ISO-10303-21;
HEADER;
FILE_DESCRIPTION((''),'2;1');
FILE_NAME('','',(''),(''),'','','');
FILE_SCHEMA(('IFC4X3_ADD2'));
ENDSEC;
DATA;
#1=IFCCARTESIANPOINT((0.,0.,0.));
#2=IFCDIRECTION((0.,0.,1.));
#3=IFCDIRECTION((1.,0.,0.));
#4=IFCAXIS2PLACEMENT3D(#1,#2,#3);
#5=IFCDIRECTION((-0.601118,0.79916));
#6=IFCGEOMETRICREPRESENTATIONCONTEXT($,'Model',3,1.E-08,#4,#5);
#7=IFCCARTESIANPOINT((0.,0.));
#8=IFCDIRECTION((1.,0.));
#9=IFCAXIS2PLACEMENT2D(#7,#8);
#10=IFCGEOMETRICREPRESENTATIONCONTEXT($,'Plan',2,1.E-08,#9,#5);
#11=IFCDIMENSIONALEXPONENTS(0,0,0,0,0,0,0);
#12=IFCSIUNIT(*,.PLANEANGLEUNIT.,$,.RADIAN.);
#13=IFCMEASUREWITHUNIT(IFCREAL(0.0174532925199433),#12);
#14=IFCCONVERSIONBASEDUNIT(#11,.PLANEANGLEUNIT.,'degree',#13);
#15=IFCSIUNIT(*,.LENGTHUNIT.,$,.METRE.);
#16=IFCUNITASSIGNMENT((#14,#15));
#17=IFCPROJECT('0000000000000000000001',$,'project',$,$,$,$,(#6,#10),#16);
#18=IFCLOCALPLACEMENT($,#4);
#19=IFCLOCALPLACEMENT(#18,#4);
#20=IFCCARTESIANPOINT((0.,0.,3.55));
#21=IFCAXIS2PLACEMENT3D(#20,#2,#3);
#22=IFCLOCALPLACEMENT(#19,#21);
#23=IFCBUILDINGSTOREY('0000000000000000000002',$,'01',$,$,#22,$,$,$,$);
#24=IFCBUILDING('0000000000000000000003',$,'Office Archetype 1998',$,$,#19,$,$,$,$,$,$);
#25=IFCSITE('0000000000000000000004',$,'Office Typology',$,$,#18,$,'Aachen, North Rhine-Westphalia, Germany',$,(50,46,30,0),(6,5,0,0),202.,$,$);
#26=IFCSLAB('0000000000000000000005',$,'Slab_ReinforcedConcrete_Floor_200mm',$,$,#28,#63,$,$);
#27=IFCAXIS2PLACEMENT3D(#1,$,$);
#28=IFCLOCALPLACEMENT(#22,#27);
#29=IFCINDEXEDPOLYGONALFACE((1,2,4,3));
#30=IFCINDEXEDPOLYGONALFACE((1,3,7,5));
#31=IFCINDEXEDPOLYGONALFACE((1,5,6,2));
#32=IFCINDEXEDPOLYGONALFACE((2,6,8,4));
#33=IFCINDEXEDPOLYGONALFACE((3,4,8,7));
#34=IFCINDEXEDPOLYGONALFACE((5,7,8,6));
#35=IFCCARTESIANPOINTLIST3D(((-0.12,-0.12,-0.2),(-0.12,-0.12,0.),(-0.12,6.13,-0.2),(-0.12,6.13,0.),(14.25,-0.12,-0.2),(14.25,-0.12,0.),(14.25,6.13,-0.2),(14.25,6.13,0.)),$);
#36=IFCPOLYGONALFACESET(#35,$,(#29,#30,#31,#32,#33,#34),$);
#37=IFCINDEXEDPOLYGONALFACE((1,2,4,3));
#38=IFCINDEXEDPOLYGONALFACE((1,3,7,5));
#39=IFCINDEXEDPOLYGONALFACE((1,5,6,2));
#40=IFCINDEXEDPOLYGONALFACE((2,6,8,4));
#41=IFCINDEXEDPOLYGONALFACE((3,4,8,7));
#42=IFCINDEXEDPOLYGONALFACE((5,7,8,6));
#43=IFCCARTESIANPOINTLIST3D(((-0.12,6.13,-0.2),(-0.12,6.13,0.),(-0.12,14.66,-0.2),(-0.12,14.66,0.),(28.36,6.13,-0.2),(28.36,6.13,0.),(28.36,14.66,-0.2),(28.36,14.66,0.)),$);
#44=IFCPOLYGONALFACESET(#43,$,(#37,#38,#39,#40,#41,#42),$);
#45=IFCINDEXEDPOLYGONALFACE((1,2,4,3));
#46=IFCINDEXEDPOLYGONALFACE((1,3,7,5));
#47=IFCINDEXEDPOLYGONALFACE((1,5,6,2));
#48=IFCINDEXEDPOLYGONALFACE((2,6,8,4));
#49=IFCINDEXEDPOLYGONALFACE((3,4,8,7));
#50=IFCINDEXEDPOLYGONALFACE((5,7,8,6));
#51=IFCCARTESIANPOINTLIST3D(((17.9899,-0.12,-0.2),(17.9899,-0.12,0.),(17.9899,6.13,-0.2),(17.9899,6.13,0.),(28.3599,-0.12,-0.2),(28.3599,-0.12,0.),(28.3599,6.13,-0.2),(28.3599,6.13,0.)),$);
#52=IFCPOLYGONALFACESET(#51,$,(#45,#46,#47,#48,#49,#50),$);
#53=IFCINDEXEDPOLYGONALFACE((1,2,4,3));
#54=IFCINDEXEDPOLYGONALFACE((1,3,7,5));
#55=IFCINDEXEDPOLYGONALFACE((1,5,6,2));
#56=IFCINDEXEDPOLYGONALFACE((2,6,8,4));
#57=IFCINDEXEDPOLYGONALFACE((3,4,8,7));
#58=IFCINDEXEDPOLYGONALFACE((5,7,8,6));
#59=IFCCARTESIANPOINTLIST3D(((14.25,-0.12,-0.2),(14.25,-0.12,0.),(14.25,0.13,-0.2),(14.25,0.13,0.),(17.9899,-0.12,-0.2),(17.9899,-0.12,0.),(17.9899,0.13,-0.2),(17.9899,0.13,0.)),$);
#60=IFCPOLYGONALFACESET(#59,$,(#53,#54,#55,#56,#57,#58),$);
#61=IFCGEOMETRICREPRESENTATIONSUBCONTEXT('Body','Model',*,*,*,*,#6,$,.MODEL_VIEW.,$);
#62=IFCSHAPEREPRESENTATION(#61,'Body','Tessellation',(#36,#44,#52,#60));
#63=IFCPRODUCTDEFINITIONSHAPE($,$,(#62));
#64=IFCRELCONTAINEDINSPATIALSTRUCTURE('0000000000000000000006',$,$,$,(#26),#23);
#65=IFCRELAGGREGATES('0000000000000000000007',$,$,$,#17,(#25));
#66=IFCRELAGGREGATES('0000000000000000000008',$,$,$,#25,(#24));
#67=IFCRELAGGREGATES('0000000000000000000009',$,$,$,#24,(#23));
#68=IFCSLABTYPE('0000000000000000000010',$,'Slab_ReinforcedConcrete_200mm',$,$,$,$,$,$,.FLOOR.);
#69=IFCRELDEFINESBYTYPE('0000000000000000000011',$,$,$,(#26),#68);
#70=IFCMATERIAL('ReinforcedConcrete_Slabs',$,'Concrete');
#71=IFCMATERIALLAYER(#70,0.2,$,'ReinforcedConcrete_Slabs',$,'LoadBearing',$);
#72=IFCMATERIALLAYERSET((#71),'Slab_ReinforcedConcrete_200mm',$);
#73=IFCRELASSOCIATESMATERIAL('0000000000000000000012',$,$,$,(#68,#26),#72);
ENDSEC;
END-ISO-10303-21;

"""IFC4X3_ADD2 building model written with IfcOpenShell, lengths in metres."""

from ifc_helpers import new_model, entity, si_unit, converted_unit, direction, frame, origin_with_axes, origin_2d_with_axis, place, context, subcontext, project, spatial, indexed_curve, outline, extrude, material, layer, layer_set, layer_usage, type_object, element, save


model = new_model("IFC4X3_ADD2")

# Units and contexts
model_context = context("Model", 3, precision=1e-08, world=origin_with_axes(), true_north=direction((-0.601118, 0.79916)))
plan_context = context("Plan", 2, precision=1e-08, world=origin_2d_with_axis(), true_north=direction((-0.601118, 0.79916)))
body_context = subcontext(model_context, "Body", "Model", "MODEL_VIEW")
ifc_project = project(units=[converted_unit("PLANEANGLEUNIT", "degree", entity("IfcReal", 0.0174532925199433), si_unit("PLANEANGLEUNIT", "RADIAN"), dimensions=[0, 0, 0, 0, 0, 0, 0]), si_unit("LENGTHUNIT", "METRE")], contexts=[model_context, plan_context])

# Site, building, storey
site_placement = place(None, origin_with_axes())
site = spatial("IfcSite", under=ifc_project, at=site_placement, Name="Office Typology", LongName="Aachen, North Rhine-Westphalia, Germany", RefLatitude=(50, 46, 30, 0), RefLongitude=(6, 5, 0, 0), RefElevation=202.0)
building_placement = place(site_placement, origin_with_axes())
building = spatial("IfcBuilding", under=site, at=building_placement, Name="Office Archetype 1998")
storey_placement = place(building_placement, frame((0.0, 0.0, 3.55), z_axis=(0.0, 0.0, 1.0), x_axis=(1.0, 0.0, 0.0)))
storey = spatial("IfcBuildingStorey", under=building, at=storey_placement, Name="01")

# Slab
ifc_material_1 = material(Name="ReinforcedConcrete_Slabs", Category="Concrete")
ifc_layer_1 = layer(ifc_material_1, 0.2, Name="ReinforcedConcrete_Slabs", Category="LoadBearing")
ifc_layer_set_1 = layer_set([ifc_layer_1], Name="Slab_ReinforcedConcrete_200mm")
slab_type_1 = type_object("IfcSlabType", Name="Slab_ReinforcedConcrete_200mm", PredefinedType="FLOOR", material=ifc_layer_set_1)
ifc_layer_usage_1 = layer_usage(ifc_layer_set_1, "AXIS3", "POSITIVE", 0.0)
slab_1_placement = place(storey_placement, frame((17.9899, 6.13, 0.0), z_axis=(0.0, 0.0, 1.0), x_axis=(1.0, 0.0, 0.0)))
element("IfcSlab", 1, at=slab_1_placement, inside=storey, type_object=slab_type_1, material=ifc_layer_usage_1, Name="Slab_ReinforcedConcrete_Floor_200mm", context=body_context, shape_type="SweptSolid", body=[
    extrude(outline(indexed_curve([(0.0, -6.25), (14.37, -6.25), (14.37, 0.0), (0.0, 0.0), (0.0, -6.25)])), frame((-18.1099, 0.0, -0.2), z_axis=(0.0, 0.0, 1.0), x_axis=(1.0, 0.0, 0.0)), (0.0, 0.0, 1.0), 0.2),
    extrude(outline(indexed_curve([(0.0, 0.0), (28.48, 0.0), (28.48, -8.53), (0.0, -8.53), (0.0, 0.0)])), frame((-18.1099, 8.53, -0.2), z_axis=(0.0, 0.0, 1.0), x_axis=(1.0, 0.0, 0.0)), (0.0, 0.0, 1.0), 0.2),
    extrude(outline(indexed_curve([(0.0, 0.0), (0.0, -6.25), (10.37, -6.25), (10.37, 0.0), (0.0, 0.0)])), frame((0.0, 0.0, -0.2), z_axis=(0.0, 0.0, 1.0), x_axis=(1.0, 0.0, 0.0)), (0.0, 0.0, 1.0), 0.2),
    extrude(outline(indexed_curve([(0.0, 0.0), (3.7399, 0.0), (3.7399, 0.25), (0.0, 0.25), (0.0, 0.0)])), frame((-3.7399, -6.25, -0.2), z_axis=(0.0, 0.0, 1.0), x_axis=(1.0, 0.0, 0.0)), (0.0, 0.0, 1.0), 0.2),
])

save(model, "model.ifc")
